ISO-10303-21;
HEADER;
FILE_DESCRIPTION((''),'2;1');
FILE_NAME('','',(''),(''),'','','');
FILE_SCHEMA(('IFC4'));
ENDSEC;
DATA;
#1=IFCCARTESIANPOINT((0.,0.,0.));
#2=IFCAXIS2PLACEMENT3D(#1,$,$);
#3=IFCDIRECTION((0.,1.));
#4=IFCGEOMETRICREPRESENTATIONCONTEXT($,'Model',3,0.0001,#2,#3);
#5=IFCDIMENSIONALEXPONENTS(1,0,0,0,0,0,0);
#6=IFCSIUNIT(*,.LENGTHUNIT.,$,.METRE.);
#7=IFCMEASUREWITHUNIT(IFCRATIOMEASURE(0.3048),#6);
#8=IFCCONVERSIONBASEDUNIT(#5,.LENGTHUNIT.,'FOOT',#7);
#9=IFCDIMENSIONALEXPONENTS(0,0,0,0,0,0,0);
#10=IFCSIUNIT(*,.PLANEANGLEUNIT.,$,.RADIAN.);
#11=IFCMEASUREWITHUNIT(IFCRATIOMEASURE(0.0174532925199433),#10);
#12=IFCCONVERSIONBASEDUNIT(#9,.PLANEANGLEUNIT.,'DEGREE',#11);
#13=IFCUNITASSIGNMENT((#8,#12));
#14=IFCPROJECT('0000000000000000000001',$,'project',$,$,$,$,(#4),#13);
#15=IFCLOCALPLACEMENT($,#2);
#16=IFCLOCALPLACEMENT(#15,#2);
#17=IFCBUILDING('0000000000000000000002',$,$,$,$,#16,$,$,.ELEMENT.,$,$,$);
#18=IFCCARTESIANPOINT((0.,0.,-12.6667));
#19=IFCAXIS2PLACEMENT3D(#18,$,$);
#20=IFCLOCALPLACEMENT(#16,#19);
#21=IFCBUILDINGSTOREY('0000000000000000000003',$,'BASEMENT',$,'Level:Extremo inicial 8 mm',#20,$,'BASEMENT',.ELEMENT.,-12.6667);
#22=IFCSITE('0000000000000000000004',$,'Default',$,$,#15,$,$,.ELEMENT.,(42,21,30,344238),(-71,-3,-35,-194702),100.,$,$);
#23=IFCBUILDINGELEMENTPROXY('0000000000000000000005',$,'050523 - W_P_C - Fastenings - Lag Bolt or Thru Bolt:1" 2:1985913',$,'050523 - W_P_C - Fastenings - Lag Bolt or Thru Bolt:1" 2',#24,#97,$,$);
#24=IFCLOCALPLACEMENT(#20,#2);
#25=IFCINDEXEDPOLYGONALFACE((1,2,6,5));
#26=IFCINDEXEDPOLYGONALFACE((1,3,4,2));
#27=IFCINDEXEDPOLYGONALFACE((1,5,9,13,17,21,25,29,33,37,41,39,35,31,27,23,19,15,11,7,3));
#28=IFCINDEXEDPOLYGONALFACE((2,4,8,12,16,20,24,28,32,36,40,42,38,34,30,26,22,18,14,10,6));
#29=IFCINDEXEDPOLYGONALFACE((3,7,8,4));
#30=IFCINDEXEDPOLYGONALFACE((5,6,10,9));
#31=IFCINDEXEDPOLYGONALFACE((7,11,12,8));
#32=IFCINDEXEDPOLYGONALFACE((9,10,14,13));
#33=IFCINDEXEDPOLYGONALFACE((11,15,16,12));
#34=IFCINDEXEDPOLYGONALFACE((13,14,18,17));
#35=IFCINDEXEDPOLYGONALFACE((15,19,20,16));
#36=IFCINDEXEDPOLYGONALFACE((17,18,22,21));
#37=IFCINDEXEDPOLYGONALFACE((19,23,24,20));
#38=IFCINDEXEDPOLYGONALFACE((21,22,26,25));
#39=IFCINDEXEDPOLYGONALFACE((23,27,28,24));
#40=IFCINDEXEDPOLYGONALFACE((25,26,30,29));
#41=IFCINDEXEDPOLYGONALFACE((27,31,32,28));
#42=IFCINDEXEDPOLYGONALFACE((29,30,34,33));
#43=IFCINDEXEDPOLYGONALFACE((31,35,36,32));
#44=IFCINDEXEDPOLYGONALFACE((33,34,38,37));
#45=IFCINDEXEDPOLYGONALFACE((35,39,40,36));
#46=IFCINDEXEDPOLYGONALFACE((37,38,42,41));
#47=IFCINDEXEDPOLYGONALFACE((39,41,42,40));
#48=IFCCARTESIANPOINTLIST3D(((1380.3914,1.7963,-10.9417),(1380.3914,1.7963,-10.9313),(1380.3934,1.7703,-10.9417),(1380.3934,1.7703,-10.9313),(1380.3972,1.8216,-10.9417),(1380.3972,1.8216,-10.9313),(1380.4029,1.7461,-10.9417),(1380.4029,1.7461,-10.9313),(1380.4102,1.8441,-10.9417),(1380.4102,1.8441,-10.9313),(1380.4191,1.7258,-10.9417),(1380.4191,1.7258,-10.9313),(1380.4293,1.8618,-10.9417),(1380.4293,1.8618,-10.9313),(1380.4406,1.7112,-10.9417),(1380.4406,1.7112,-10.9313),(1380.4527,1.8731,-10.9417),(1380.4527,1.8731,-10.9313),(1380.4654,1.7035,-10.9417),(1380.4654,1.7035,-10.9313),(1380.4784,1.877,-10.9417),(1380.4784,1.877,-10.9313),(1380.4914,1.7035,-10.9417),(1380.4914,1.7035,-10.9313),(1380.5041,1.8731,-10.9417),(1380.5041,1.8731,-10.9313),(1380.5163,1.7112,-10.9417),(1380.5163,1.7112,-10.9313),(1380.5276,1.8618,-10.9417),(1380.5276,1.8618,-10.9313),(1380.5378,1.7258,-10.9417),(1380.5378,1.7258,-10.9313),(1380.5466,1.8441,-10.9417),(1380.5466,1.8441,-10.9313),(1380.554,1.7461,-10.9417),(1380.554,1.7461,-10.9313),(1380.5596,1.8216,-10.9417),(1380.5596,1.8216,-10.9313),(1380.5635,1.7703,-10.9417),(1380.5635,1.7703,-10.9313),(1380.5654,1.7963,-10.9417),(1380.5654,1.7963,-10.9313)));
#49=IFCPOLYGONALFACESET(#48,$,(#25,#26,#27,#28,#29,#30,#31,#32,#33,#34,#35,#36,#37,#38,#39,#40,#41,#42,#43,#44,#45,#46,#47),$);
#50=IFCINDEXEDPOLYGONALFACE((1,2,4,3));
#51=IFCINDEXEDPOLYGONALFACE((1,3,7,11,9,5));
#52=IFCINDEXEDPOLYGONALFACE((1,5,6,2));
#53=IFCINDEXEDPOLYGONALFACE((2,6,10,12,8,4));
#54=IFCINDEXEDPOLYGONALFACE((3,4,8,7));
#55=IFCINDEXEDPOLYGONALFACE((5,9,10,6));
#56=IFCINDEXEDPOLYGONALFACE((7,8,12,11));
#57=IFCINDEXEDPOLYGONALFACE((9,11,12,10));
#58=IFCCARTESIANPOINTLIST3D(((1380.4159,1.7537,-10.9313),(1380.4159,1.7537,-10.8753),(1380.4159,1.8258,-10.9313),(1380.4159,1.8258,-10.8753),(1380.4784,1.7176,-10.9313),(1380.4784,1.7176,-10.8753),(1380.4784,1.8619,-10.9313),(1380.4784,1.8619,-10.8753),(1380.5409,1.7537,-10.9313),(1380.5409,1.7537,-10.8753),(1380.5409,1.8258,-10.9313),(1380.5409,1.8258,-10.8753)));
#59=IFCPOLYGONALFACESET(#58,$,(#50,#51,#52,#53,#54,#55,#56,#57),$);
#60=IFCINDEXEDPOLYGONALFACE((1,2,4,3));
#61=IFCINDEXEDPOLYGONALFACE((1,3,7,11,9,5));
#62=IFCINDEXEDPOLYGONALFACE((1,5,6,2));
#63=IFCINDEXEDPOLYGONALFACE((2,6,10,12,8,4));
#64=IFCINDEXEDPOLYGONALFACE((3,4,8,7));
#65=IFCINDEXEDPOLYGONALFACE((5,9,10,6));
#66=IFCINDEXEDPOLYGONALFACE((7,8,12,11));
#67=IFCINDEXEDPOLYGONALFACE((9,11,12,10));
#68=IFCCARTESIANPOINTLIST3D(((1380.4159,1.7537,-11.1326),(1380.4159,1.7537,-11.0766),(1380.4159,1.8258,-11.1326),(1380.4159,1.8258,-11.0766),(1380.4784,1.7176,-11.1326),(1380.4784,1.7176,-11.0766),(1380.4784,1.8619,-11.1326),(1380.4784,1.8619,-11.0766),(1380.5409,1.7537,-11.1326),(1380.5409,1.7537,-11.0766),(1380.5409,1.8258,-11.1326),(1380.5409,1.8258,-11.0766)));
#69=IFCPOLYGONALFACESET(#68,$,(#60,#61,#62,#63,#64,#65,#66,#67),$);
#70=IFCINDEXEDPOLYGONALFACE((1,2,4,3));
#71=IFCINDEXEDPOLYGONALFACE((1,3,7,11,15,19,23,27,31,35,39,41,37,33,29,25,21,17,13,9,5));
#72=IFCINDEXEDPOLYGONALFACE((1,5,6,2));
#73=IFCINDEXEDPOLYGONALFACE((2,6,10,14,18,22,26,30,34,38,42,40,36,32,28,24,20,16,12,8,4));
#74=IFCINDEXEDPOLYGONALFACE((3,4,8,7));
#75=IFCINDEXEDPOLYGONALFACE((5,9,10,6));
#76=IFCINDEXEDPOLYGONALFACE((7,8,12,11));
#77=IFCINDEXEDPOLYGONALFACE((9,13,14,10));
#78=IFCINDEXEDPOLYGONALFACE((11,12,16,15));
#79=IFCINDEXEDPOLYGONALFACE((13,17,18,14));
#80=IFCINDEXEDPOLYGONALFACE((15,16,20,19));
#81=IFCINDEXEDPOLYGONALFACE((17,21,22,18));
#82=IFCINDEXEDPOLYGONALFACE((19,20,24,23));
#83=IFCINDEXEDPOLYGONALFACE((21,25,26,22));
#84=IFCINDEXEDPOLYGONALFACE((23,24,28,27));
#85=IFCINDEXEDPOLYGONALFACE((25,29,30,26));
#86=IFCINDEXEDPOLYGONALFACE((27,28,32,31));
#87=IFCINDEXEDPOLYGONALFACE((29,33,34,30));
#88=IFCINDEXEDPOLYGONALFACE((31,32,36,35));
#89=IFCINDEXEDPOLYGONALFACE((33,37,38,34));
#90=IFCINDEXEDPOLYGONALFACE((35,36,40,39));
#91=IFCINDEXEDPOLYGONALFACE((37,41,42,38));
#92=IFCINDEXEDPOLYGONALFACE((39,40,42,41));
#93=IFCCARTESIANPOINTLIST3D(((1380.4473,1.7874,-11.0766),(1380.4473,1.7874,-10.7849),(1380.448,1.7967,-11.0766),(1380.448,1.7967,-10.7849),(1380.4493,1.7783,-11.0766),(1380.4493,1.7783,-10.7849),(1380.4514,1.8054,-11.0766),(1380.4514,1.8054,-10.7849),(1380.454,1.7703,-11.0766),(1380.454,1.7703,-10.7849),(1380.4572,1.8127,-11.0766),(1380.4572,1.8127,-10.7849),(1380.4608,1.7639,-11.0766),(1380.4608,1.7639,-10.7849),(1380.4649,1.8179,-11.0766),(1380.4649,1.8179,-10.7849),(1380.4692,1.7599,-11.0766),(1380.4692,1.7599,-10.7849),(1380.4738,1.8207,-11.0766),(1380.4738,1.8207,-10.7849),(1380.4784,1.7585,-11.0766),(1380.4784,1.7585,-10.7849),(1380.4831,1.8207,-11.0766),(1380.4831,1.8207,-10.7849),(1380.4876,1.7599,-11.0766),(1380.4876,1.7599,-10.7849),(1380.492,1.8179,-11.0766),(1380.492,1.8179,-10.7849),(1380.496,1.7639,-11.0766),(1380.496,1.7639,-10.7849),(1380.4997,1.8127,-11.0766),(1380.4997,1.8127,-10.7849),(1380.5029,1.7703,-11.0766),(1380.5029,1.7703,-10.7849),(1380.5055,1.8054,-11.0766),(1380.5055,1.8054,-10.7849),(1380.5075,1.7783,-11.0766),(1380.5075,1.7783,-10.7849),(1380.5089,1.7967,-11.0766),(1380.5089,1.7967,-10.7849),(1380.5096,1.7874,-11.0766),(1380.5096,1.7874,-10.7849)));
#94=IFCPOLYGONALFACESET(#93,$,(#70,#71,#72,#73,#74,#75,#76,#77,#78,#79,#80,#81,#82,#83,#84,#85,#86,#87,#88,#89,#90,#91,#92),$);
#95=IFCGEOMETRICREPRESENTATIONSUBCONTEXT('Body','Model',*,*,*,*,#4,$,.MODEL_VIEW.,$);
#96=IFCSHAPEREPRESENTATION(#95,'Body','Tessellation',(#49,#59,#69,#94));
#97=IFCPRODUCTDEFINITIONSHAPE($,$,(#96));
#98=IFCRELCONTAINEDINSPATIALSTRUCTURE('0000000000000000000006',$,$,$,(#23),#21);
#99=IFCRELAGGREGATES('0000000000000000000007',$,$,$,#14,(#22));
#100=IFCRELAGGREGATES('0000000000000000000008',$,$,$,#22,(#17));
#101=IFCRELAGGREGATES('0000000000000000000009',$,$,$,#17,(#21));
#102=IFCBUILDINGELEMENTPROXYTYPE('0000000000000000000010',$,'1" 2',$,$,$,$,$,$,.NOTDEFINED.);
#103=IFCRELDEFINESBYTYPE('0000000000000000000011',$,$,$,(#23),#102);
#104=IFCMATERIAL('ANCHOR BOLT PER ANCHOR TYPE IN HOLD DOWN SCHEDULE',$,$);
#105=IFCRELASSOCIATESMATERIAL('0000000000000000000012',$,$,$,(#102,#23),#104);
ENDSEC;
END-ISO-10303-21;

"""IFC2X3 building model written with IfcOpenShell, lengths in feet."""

from ifc_helpers import new_model, entity, si_unit, converted_unit, direction, frame, frame_2d, origin, place, context, subcontext, project, spatial, polyline, circle, outline, extrude, source, transform, mapped, material, type_object, type_shapes, element, save


model = new_model("IFC2X3")

# Units and contexts
model_context = context("Model", 3, precision=0.0001, world=origin(), true_north=direction((0.0, 1.0)))
body_context = subcontext(model_context, "Body", "Model", "MODEL_VIEW")
ifc_project = project(units=[converted_unit("LENGTHUNIT", "FOOT", entity("IfcRatioMeasure", 0.3048), si_unit("LENGTHUNIT", "METRE"), dimensions=[1, 0, 0, 0, 0, 0, 0]), converted_unit("PLANEANGLEUNIT", "DEGREE", entity("IfcRatioMeasure", 0.0174532925199433), si_unit("PLANEANGLEUNIT", "RADIAN"), dimensions=[0, 0, 0, 0, 0, 0, 0])], contexts=[model_context])

# Site, building, storey
site_placement = place(None, origin())
site = spatial("IfcSite", under=ifc_project, at=site_placement, Name="Default", CompositionType="ELEMENT", RefLatitude=(42, 21, 30, 344238), RefLongitude=(-71, -3, -35, -194702), RefElevation=100.0)
building_placement = place(site_placement, origin())
building = spatial("IfcBuilding", under=site, at=building_placement, CompositionType="ELEMENT")
storey_placement = place(building_placement, frame((0.0, 0.0, -12.6667)))
storey = spatial("IfcBuildingStorey", under=building, at=storey_placement, Name="BASEMENT", ObjectType="Level:Extremo inicial 8 mm", LongName="BASEMENT", CompositionType="ELEMENT", Elevation=-12.6667)

# Building element proxy
ifc_material_1 = material(Name="ANCHOR BOLT PER ANCHOR TYPE IN HOLD DOWN SCHEDULE")
building_element_proxy_type_1 = type_object("IfcBuildingElementProxyType", Name="1\" 2", PredefinedType="NOTDEFINED", material=ifc_material_1)
shared_shape_1 = source(origin(), body_context, "Body", "SweptSolid", [
    extrude(circle(Radius=0.0872, at=frame_2d((0.0, 0.0), x_axis=(1.0, 0.0))), frame((0.0, 0.0, -0.1453), z_axis=(0.0, 0.0, 1.0), x_axis=(0.0, -1.0, 0.0)), (0.0, 0.0, 1.0), 0.0104),
    extrude(outline(polyline([(-0.0361, -0.0625), (0.0361, -0.0625), (0.0722, 0.0), (0.0361, 0.0625), (-0.0361, 0.0625), (-0.0722, 0.0), (-0.0361, -0.0625)])), frame((0.0, 0.0, -0.2013), z_axis=(0.0, 0.0, 1.0), x_axis=(0.866025, -0.5, 0.0)), (0.0, 0.0, 1.0), 0.056),
    extrude(outline(polyline([(-0.0361, -0.0625), (0.0361, -0.0625), (0.0722, 0.0), (0.0361, 0.0625), (-0.0361, 0.0625), (-0.0722, 0.0), (-0.0361, -0.0625)])), frame((0.0, 0.0, 0.0), z_axis=(0.0, 0.0, 1.0), x_axis=(0.0, -1.0, 0.0)), (0.0, 0.0, 1.0), 0.056),
    extrude(circle(Radius=0.0312, at=frame_2d((0.0, 0.0), x_axis=(1.0, 0.0))), frame((0.0, 0.0, -0.2917), z_axis=(0.0, 0.0, 1.0), x_axis=(0.0, 1.0, 0.0)), (0.0, 0.0, 1.0), 0.2917),
])
type_shapes(building_element_proxy_type_1, [shared_shape_1])
proxy_1_placement = place(storey_placement, frame((1380.4784, 1.7898, -11.0766), z_axis=(0.0, 0.0, -1.0), x_axis=(1.0, 0.0, 0.0)))
element("IfcBuildingElementProxy", 1, at=proxy_1_placement, inside=storey, type_object=building_element_proxy_type_1, material=ifc_material_1, Name="050523 - W_P_C - Fastenings - Lag Bolt or Thru Bolt:1\" 2:1985913", ObjectType="050523 - W_P_C - Fastenings - Lag Bolt or Thru Bolt:1\" 2", context=body_context, shape_type="MappedRepresentation", body=[
    mapped(shared_shape_1, transform((0.0, 0.0, 0.0), scale=1.0)),
])

save(model, "model.ifc")
